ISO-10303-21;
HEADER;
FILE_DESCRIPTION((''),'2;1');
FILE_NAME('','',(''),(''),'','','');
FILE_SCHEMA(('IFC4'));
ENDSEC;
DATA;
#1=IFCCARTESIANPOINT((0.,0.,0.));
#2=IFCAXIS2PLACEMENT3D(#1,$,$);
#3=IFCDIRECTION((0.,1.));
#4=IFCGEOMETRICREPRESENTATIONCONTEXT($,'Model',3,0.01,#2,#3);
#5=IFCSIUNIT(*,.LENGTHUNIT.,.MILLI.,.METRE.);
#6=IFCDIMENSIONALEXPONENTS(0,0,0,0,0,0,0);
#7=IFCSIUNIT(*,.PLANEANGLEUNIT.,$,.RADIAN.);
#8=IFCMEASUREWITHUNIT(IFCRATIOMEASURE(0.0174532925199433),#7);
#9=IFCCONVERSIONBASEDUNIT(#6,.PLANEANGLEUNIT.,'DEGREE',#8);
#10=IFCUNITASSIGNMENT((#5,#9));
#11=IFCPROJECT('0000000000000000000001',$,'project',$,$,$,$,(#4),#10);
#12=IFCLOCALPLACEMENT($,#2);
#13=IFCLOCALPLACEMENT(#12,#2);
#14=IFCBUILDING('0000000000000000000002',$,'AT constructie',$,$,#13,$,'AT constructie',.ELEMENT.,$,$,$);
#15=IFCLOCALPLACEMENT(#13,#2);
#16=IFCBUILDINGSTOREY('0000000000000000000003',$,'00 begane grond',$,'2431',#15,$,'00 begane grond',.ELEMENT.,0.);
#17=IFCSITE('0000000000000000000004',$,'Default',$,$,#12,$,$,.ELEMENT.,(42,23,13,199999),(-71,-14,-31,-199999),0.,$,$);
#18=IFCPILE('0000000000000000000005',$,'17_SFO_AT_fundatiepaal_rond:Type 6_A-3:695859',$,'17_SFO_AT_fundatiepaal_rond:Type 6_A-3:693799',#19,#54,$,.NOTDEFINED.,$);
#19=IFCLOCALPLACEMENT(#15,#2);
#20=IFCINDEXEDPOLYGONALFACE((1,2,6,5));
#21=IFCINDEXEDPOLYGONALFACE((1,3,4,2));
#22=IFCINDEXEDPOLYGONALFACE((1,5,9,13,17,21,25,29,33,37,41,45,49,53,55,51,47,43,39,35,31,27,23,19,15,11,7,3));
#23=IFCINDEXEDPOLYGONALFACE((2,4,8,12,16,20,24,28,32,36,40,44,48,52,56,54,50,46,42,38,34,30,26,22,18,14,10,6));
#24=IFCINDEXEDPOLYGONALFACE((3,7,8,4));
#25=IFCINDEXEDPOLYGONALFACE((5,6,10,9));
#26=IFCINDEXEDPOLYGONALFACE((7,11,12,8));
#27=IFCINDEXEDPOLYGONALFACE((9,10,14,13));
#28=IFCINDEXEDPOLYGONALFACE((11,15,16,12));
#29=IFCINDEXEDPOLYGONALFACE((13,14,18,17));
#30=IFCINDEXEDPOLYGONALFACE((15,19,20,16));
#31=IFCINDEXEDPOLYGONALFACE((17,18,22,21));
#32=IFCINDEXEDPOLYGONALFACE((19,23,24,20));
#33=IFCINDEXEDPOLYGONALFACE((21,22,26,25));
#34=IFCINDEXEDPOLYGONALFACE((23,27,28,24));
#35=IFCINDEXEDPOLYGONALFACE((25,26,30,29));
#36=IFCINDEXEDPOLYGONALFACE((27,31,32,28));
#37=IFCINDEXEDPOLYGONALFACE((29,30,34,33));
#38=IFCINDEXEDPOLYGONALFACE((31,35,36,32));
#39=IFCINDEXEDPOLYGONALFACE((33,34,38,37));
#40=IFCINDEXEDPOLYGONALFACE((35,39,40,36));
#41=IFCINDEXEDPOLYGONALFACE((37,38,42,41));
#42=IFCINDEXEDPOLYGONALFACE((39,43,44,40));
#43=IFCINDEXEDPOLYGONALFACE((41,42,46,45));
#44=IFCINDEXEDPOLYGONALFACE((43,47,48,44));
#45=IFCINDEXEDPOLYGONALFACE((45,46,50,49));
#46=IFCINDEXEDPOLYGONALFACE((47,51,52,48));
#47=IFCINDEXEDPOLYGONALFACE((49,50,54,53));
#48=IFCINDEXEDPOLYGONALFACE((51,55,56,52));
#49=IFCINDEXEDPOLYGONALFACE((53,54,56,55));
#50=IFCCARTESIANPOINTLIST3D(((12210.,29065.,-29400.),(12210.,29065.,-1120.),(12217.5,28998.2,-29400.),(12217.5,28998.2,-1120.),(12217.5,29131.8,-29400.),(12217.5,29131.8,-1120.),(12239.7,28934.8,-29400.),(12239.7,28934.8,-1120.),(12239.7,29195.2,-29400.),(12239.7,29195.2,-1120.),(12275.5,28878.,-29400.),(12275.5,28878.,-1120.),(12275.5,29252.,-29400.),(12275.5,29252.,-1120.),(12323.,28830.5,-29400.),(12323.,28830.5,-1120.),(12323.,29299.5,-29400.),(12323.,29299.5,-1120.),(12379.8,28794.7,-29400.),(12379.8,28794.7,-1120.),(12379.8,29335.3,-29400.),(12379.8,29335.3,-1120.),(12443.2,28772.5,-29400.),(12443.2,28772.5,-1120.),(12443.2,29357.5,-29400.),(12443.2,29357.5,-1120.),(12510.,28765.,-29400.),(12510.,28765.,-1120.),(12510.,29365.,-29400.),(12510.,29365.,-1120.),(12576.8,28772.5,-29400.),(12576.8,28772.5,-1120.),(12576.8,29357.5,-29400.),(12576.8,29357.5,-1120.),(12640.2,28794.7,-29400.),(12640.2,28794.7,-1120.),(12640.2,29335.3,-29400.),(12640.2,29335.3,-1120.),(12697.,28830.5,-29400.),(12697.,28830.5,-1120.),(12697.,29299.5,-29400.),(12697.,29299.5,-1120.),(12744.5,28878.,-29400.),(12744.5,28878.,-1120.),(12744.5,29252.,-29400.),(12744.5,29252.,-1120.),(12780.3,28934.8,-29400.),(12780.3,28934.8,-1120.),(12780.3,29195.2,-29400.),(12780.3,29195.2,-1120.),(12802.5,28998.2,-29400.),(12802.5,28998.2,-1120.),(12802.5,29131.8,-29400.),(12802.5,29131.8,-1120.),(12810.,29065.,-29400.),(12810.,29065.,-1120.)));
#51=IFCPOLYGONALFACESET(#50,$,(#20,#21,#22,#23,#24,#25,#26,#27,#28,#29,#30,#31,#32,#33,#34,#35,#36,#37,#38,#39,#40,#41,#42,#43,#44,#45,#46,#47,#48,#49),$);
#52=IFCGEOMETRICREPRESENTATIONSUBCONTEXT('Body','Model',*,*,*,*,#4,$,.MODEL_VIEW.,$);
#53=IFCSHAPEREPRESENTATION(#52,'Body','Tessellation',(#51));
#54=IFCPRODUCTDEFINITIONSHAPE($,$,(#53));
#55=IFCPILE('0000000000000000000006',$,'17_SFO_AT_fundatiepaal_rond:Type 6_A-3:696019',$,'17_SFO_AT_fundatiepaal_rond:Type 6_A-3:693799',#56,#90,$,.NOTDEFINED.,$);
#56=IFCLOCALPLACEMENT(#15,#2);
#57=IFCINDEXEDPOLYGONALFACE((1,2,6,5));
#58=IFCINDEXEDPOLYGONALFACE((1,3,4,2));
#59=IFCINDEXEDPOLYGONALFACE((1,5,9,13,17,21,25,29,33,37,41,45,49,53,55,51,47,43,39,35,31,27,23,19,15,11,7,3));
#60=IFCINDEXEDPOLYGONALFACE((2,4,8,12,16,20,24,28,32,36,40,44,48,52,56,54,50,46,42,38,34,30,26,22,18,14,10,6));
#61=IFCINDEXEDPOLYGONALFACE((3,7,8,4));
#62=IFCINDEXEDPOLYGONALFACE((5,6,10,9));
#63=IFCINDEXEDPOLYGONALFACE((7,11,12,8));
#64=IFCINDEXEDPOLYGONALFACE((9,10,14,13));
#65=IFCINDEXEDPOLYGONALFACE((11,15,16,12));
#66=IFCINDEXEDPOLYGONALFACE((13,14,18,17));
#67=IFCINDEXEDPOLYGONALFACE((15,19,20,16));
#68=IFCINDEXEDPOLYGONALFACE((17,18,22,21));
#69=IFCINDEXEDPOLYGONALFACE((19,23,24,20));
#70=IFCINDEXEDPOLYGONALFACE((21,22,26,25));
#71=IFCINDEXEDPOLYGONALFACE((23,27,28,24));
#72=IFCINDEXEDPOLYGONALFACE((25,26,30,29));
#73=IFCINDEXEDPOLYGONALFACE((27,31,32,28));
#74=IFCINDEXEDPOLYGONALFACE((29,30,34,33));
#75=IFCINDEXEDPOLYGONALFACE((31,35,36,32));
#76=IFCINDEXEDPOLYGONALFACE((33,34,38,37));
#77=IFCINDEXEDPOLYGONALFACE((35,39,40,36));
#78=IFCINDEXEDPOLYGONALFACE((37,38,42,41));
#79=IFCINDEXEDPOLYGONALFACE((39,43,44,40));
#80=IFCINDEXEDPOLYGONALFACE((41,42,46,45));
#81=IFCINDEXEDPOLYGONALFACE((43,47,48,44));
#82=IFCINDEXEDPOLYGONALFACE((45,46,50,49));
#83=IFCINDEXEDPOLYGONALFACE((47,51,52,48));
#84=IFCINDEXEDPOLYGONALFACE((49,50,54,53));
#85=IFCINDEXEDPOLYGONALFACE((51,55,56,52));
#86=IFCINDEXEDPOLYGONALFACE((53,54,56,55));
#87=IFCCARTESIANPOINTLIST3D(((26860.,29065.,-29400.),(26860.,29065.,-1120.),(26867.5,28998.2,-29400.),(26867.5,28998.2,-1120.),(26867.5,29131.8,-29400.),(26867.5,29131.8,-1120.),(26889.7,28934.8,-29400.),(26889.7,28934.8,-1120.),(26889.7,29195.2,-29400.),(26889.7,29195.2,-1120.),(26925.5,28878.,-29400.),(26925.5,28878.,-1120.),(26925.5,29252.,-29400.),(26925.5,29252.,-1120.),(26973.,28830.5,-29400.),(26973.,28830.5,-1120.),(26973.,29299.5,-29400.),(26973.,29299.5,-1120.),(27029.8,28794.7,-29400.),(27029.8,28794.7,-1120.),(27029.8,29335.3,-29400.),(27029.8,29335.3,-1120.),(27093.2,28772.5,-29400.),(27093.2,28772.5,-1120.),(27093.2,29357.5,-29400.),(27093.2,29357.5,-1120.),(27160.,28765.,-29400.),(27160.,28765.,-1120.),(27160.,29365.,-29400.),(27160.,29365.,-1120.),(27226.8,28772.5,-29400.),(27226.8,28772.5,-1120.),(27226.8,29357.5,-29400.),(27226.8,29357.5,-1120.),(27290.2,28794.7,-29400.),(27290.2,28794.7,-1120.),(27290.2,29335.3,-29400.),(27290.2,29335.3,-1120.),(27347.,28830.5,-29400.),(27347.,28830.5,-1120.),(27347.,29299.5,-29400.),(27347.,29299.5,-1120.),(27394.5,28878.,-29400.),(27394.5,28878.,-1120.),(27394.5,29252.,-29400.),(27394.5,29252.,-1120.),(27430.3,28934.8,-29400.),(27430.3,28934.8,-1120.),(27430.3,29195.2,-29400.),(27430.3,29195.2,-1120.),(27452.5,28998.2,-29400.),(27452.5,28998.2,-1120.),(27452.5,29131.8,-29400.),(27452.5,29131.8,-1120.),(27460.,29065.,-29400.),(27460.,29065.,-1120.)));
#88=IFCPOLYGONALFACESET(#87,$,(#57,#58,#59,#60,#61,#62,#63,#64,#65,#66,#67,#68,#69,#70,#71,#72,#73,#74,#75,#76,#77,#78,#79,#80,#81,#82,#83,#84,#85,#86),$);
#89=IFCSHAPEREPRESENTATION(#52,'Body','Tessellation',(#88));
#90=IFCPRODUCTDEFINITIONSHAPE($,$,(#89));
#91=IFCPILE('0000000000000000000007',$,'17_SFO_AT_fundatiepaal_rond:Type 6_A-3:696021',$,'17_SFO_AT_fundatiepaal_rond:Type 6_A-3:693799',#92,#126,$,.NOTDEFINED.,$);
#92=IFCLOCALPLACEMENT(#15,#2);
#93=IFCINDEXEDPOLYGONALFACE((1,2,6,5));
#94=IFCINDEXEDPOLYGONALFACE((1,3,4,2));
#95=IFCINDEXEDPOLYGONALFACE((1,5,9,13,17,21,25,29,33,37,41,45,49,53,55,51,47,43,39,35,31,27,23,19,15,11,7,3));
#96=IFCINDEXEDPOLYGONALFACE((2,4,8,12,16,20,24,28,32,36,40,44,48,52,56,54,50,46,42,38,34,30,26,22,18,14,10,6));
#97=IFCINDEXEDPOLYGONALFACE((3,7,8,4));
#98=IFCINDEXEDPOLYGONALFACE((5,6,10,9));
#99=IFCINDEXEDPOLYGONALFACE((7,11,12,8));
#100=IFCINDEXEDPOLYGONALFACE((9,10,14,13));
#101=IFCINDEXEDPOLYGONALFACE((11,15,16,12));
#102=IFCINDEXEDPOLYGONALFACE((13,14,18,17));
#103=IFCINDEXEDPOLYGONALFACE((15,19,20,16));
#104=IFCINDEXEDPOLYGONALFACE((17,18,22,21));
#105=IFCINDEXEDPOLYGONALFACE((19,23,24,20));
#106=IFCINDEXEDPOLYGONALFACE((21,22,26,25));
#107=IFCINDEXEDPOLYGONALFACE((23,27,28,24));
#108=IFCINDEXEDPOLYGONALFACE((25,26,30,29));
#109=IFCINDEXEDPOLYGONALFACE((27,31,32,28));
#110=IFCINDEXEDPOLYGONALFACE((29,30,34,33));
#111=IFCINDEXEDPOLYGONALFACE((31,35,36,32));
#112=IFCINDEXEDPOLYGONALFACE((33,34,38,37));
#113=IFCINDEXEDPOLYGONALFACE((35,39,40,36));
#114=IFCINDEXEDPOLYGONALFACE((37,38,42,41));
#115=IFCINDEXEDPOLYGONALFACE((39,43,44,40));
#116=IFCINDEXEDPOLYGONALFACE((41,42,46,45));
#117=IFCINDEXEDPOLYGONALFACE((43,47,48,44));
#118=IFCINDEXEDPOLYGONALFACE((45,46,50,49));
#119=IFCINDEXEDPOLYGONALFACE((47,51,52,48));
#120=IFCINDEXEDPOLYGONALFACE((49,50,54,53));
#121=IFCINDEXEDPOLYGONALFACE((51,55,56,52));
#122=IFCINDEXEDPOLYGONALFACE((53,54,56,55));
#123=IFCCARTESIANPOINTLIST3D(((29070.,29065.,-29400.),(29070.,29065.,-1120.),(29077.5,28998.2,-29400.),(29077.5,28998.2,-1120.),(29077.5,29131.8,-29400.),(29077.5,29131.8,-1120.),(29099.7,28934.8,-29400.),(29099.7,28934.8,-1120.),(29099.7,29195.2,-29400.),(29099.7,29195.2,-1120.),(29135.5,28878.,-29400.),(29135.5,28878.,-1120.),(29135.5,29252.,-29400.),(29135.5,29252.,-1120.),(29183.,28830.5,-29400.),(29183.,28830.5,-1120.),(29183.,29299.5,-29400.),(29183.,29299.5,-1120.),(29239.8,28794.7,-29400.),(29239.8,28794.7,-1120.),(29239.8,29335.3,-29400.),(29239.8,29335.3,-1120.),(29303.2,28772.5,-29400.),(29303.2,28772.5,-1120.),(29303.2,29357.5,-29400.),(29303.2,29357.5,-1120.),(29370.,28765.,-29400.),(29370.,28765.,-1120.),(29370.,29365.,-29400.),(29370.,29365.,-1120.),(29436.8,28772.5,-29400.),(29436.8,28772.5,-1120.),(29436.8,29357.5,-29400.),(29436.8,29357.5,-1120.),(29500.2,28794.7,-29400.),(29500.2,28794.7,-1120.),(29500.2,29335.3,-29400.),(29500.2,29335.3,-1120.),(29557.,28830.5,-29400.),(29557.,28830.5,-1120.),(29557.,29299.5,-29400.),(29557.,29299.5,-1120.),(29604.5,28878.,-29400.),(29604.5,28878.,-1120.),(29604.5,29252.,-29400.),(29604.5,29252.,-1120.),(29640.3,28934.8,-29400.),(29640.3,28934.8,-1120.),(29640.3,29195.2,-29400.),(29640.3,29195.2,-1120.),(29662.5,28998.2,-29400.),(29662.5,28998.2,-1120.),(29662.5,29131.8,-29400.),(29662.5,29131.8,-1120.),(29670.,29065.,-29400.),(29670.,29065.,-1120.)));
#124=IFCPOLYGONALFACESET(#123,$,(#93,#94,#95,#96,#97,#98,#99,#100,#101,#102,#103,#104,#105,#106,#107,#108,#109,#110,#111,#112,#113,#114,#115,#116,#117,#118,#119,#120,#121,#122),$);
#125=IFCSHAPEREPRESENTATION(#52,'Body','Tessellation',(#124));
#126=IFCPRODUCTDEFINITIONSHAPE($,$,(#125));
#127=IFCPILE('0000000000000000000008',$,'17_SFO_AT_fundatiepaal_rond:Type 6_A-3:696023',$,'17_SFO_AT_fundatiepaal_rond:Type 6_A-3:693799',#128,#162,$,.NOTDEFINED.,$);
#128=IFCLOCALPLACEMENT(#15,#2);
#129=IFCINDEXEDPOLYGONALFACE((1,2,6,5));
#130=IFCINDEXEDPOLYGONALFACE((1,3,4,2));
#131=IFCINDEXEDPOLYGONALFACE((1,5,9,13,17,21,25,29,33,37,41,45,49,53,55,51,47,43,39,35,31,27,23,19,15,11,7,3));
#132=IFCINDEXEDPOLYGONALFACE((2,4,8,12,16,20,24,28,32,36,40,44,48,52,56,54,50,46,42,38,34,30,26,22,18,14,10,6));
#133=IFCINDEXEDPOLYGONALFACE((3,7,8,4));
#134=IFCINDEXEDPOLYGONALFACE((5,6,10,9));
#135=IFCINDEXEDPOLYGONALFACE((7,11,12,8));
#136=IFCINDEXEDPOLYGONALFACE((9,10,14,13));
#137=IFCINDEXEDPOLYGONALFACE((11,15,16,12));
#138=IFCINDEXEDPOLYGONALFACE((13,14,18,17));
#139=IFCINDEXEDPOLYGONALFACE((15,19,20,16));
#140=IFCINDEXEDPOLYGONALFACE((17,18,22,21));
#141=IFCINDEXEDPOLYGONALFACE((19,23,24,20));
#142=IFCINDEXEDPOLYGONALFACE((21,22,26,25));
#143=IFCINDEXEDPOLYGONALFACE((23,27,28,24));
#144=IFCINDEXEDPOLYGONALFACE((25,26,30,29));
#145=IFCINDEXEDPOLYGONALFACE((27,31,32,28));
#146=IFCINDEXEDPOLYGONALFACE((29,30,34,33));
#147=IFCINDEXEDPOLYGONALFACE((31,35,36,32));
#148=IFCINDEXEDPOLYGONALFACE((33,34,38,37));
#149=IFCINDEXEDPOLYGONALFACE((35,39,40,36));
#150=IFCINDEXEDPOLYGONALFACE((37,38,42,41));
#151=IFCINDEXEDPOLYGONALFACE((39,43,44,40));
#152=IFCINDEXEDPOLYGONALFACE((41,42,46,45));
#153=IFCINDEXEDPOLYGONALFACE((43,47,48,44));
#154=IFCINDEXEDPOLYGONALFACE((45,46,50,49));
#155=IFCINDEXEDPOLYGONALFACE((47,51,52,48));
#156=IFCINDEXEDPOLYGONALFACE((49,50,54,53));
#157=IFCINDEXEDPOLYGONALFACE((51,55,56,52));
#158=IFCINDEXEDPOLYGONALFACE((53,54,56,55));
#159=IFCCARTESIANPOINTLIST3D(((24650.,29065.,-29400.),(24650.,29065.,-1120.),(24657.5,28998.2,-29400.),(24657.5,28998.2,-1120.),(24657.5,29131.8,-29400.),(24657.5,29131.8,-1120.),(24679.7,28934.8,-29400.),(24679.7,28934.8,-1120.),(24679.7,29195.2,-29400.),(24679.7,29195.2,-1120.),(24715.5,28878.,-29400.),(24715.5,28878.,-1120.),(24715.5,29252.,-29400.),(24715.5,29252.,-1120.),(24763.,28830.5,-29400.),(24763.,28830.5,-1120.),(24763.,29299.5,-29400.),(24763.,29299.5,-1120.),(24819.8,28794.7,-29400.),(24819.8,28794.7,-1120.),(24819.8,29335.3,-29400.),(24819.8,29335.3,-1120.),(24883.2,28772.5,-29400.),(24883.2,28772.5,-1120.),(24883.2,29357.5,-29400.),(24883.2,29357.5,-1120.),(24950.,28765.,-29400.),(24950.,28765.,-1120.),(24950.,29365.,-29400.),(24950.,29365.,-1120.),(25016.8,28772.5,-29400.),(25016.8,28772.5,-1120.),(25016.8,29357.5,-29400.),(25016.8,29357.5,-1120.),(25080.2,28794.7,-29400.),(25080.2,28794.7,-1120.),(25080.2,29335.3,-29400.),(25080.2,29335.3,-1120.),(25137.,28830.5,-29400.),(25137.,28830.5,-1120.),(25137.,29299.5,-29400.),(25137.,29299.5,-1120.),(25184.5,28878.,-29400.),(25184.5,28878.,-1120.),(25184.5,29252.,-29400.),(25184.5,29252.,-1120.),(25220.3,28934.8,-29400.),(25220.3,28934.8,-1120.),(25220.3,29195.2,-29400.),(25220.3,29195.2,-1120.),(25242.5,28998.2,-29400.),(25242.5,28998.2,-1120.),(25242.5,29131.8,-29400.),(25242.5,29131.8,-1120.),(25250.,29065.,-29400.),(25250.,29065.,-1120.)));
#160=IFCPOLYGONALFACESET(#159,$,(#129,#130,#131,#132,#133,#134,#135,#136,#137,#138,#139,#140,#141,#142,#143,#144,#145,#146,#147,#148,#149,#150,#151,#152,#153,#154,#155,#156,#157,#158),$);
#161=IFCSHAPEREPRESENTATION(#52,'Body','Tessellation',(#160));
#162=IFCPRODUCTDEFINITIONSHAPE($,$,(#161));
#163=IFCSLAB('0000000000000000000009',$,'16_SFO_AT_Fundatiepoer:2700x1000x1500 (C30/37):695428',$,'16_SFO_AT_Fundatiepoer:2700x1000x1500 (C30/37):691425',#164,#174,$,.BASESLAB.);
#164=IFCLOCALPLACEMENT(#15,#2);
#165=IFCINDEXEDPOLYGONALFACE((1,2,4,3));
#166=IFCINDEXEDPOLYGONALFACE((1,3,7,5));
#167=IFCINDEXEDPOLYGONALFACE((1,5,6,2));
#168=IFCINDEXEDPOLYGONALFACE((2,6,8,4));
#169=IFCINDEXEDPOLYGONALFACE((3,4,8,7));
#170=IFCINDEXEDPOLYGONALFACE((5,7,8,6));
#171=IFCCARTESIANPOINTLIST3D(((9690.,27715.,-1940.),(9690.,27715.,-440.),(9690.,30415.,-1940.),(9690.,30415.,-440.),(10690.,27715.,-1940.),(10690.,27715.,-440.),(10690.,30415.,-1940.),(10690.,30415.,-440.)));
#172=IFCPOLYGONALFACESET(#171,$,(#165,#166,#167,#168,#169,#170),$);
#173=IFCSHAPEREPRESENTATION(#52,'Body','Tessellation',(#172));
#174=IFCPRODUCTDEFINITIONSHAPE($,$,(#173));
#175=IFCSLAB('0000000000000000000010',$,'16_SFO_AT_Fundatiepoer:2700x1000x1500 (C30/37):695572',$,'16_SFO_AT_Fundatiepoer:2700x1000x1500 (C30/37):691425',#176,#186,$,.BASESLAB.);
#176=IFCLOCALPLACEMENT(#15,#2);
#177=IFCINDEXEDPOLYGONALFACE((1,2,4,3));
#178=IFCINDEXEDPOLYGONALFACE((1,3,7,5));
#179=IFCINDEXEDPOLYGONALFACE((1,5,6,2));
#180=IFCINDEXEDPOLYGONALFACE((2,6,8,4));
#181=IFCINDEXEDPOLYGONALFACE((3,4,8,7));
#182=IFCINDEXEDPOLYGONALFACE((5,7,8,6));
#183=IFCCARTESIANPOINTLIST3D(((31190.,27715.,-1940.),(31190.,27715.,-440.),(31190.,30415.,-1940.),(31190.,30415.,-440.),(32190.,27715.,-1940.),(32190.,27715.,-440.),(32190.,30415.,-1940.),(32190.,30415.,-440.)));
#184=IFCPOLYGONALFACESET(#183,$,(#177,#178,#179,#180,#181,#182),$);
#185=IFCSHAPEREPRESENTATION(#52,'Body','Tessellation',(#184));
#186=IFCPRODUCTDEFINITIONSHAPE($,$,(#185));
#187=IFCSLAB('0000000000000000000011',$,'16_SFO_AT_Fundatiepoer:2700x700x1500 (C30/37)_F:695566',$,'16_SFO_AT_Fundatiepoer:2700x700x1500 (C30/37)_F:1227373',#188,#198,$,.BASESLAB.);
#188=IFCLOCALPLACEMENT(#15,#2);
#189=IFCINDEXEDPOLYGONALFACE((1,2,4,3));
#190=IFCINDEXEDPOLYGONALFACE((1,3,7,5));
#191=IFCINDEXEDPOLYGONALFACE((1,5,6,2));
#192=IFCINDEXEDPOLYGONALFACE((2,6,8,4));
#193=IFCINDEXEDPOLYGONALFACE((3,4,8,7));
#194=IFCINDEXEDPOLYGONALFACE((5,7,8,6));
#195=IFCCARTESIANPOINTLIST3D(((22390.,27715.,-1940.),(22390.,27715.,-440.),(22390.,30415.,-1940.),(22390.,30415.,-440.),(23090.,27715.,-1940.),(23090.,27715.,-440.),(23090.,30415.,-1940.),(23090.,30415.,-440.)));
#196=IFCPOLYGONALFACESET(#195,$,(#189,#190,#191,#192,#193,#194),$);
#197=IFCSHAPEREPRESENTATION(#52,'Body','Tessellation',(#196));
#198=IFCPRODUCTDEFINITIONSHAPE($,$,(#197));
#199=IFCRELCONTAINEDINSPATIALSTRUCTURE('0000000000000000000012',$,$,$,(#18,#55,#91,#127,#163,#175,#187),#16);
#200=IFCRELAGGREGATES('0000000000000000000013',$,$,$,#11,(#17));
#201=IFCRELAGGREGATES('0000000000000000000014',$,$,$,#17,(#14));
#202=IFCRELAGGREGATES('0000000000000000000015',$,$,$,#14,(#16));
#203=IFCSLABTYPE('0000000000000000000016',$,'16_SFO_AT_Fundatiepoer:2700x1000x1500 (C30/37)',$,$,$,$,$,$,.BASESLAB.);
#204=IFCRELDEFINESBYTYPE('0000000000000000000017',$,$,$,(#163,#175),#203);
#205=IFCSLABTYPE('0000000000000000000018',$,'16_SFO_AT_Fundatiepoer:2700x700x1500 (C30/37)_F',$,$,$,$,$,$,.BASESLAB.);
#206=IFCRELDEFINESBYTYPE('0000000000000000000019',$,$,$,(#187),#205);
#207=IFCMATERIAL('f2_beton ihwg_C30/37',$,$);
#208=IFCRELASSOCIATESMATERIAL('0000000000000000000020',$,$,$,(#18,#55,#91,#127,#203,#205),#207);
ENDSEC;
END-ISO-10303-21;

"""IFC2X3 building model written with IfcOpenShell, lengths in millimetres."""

from ifc_helpers import new_model, entity, si_unit, converted_unit, direction, frame, frame_2d, origin, origin_2d_with_axis, place, context, subcontext, project, spatial, rectangle, circle, extrude, material, type_object, element, save


model = new_model("IFC2X3")

# Units and contexts
model_context = context("Model", 3, precision=0.01, world=origin(), true_north=direction((0.0, 1.0)))
body_context = subcontext(model_context, "Body", "Model", "MODEL_VIEW")
ifc_project = project(units=[si_unit("LENGTHUNIT", "METRE", prefix="MILLI"), converted_unit("PLANEANGLEUNIT", "DEGREE", entity("IfcRatioMeasure", 0.0174532925199433), si_unit("PLANEANGLEUNIT", "RADIAN"), dimensions=[0, 0, 0, 0, 0, 0, 0])], contexts=[model_context])

# Site, building, storey
site_placement = place(None, origin())
site = spatial("IfcSite", under=ifc_project, at=site_placement, Name="Default", CompositionType="ELEMENT", RefLatitude=(42, 23, 13, 199999), RefLongitude=(-71, -14, -31, -199999), RefElevation=0.0)
building_placement = place(site_placement, origin())
building = spatial("IfcBuilding", under=site, at=building_placement, Name="AT constructie", LongName="AT constructie", CompositionType="ELEMENT")
storey_placement = place(building_placement, origin())
storey = spatial("IfcBuildingStorey", under=building, at=storey_placement, Name="00 begane grond", ObjectType="2431", LongName="00 begane grond", CompositionType="ELEMENT", Elevation=0.0)

# Shared definitions
ifc_material = material(Name="f2_beton ihwg_C30/37")

# Piles
pile_1_placement = place(storey_placement, origin())
element("IfcPile", 1, at=pile_1_placement, inside=storey, material=ifc_material, Name="17_SFO_AT_fundatiepaal_rond:Type 6_A-3:695859", ObjectType="17_SFO_AT_fundatiepaal_rond:Type 6_A-3:693799", PredefinedType="NOTDEFINED", context=body_context, shape_type="SweptSolid", body=[
    extrude(circle(Radius=300.0, at=origin_2d_with_axis()), frame((12510.0, 29065.0, -29400.0)), (0.0, 0.0, 1.0), 28280.0),
])
pile_2_placement = place(storey_placement, origin())
element("IfcPile", 2, at=pile_2_placement, inside=storey, material=ifc_material, Name="17_SFO_AT_fundatiepaal_rond:Type 6_A-3:696019", ObjectType="17_SFO_AT_fundatiepaal_rond:Type 6_A-3:693799", PredefinedType="NOTDEFINED", context=body_context, shape_type="SweptSolid", body=[
    extrude(circle(Radius=300.0, at=origin_2d_with_axis()), frame((27160.0, 29065.0, -29400.0)), (0.0, 0.0, 1.0), 28280.0),
])
pile_3_placement = place(storey_placement, origin())
element("IfcPile", 3, at=pile_3_placement, inside=storey, material=ifc_material, Name="17_SFO_AT_fundatiepaal_rond:Type 6_A-3:696021", ObjectType="17_SFO_AT_fundatiepaal_rond:Type 6_A-3:693799", PredefinedType="NOTDEFINED", context=body_context, shape_type="SweptSolid", body=[
    extrude(circle(Radius=300.0, at=origin_2d_with_axis()), frame((29370.0, 29065.0, -29400.0)), (0.0, 0.0, 1.0), 28280.0),
])
pile_4_placement = place(storey_placement, origin())
element("IfcPile", 4, at=pile_4_placement, inside=storey, material=ifc_material, Name="17_SFO_AT_fundatiepaal_rond:Type 6_A-3:696023", ObjectType="17_SFO_AT_fundatiepaal_rond:Type 6_A-3:693799", PredefinedType="NOTDEFINED", context=body_context, shape_type="SweptSolid", body=[
    extrude(circle(Radius=300.0, at=origin_2d_with_axis()), frame((24950.0, 29065.0, -29400.0)), (0.0, 0.0, 1.0), 28280.0),
])

# Slabs
slab_type_1 = type_object("IfcSlabType", Name="16_SFO_AT_Fundatiepoer:2700x1000x1500 (C30/37)", PredefinedType="BASESLAB", material=ifc_material)
slab_1_placement = place(storey_placement, origin())
element("IfcSlab", 5, at=slab_1_placement, inside=storey, type_object=slab_type_1, Name="16_SFO_AT_Fundatiepoer:2700x1000x1500 (C30/37):695428", ObjectType="16_SFO_AT_Fundatiepoer:2700x1000x1500 (C30/37):691425", PredefinedType="BASESLAB", context=body_context, shape_type="SweptSolid", body=[
    extrude(rectangle(XDim=1000.0, YDim=2700.0, at=frame_2d((0.0, 0.0), x_axis=(1.0, 0.0))), frame((10190.0, 29065.0, -1940.0), z_axis=(0.0, 0.0, 1.0), x_axis=(-1.0, 0.0, 0.0)), (0.0, 0.0, 1.0), 1500.0),
])
slab_2_placement = place(storey_placement, origin())
element("IfcSlab", 6, at=slab_2_placement, inside=storey, type_object=slab_type_1, Name="16_SFO_AT_Fundatiepoer:2700x1000x1500 (C30/37):695572", ObjectType="16_SFO_AT_Fundatiepoer:2700x1000x1500 (C30/37):691425", PredefinedType="BASESLAB", context=body_context, shape_type="SweptSolid", body=[
    extrude(rectangle(XDim=1000.0, YDim=2700.0, at=origin_2d_with_axis()), frame((31690.0, 29065.0, -1940.0), z_axis=(0.0, 0.0, 1.0), x_axis=(-1.0, 0.0, 0.0)), (0.0, 0.0, 1.0), 1500.0),
])
slab_type_2 = type_object("IfcSlabType", Name="16_SFO_AT_Fundatiepoer:2700x700x1500 (C30/37)_F", PredefinedType="BASESLAB", material=ifc_material)
slab_3_placement = place(storey_placement, origin())
element("IfcSlab", 7, at=slab_3_placement, inside=storey, type_object=slab_type_2, Name="16_SFO_AT_Fundatiepoer:2700x700x1500 (C30/37)_F:695566", ObjectType="16_SFO_AT_Fundatiepoer:2700x700x1500 (C30/37)_F:1227373", PredefinedType="BASESLAB", context=body_context, shape_type="SweptSolid", body=[
    extrude(rectangle(XDim=700.0, YDim=2700.0, at=frame_2d((0.0, 0.0), x_axis=(1.0, 0.0))), frame((22740.0, 29065.0, -1940.0), z_axis=(0.0, 0.0, 1.0), x_axis=(-1.0, 0.0, 0.0)), (0.0, 0.0, 1.0), 1500.0),
])

save(model, "model.ifc")
